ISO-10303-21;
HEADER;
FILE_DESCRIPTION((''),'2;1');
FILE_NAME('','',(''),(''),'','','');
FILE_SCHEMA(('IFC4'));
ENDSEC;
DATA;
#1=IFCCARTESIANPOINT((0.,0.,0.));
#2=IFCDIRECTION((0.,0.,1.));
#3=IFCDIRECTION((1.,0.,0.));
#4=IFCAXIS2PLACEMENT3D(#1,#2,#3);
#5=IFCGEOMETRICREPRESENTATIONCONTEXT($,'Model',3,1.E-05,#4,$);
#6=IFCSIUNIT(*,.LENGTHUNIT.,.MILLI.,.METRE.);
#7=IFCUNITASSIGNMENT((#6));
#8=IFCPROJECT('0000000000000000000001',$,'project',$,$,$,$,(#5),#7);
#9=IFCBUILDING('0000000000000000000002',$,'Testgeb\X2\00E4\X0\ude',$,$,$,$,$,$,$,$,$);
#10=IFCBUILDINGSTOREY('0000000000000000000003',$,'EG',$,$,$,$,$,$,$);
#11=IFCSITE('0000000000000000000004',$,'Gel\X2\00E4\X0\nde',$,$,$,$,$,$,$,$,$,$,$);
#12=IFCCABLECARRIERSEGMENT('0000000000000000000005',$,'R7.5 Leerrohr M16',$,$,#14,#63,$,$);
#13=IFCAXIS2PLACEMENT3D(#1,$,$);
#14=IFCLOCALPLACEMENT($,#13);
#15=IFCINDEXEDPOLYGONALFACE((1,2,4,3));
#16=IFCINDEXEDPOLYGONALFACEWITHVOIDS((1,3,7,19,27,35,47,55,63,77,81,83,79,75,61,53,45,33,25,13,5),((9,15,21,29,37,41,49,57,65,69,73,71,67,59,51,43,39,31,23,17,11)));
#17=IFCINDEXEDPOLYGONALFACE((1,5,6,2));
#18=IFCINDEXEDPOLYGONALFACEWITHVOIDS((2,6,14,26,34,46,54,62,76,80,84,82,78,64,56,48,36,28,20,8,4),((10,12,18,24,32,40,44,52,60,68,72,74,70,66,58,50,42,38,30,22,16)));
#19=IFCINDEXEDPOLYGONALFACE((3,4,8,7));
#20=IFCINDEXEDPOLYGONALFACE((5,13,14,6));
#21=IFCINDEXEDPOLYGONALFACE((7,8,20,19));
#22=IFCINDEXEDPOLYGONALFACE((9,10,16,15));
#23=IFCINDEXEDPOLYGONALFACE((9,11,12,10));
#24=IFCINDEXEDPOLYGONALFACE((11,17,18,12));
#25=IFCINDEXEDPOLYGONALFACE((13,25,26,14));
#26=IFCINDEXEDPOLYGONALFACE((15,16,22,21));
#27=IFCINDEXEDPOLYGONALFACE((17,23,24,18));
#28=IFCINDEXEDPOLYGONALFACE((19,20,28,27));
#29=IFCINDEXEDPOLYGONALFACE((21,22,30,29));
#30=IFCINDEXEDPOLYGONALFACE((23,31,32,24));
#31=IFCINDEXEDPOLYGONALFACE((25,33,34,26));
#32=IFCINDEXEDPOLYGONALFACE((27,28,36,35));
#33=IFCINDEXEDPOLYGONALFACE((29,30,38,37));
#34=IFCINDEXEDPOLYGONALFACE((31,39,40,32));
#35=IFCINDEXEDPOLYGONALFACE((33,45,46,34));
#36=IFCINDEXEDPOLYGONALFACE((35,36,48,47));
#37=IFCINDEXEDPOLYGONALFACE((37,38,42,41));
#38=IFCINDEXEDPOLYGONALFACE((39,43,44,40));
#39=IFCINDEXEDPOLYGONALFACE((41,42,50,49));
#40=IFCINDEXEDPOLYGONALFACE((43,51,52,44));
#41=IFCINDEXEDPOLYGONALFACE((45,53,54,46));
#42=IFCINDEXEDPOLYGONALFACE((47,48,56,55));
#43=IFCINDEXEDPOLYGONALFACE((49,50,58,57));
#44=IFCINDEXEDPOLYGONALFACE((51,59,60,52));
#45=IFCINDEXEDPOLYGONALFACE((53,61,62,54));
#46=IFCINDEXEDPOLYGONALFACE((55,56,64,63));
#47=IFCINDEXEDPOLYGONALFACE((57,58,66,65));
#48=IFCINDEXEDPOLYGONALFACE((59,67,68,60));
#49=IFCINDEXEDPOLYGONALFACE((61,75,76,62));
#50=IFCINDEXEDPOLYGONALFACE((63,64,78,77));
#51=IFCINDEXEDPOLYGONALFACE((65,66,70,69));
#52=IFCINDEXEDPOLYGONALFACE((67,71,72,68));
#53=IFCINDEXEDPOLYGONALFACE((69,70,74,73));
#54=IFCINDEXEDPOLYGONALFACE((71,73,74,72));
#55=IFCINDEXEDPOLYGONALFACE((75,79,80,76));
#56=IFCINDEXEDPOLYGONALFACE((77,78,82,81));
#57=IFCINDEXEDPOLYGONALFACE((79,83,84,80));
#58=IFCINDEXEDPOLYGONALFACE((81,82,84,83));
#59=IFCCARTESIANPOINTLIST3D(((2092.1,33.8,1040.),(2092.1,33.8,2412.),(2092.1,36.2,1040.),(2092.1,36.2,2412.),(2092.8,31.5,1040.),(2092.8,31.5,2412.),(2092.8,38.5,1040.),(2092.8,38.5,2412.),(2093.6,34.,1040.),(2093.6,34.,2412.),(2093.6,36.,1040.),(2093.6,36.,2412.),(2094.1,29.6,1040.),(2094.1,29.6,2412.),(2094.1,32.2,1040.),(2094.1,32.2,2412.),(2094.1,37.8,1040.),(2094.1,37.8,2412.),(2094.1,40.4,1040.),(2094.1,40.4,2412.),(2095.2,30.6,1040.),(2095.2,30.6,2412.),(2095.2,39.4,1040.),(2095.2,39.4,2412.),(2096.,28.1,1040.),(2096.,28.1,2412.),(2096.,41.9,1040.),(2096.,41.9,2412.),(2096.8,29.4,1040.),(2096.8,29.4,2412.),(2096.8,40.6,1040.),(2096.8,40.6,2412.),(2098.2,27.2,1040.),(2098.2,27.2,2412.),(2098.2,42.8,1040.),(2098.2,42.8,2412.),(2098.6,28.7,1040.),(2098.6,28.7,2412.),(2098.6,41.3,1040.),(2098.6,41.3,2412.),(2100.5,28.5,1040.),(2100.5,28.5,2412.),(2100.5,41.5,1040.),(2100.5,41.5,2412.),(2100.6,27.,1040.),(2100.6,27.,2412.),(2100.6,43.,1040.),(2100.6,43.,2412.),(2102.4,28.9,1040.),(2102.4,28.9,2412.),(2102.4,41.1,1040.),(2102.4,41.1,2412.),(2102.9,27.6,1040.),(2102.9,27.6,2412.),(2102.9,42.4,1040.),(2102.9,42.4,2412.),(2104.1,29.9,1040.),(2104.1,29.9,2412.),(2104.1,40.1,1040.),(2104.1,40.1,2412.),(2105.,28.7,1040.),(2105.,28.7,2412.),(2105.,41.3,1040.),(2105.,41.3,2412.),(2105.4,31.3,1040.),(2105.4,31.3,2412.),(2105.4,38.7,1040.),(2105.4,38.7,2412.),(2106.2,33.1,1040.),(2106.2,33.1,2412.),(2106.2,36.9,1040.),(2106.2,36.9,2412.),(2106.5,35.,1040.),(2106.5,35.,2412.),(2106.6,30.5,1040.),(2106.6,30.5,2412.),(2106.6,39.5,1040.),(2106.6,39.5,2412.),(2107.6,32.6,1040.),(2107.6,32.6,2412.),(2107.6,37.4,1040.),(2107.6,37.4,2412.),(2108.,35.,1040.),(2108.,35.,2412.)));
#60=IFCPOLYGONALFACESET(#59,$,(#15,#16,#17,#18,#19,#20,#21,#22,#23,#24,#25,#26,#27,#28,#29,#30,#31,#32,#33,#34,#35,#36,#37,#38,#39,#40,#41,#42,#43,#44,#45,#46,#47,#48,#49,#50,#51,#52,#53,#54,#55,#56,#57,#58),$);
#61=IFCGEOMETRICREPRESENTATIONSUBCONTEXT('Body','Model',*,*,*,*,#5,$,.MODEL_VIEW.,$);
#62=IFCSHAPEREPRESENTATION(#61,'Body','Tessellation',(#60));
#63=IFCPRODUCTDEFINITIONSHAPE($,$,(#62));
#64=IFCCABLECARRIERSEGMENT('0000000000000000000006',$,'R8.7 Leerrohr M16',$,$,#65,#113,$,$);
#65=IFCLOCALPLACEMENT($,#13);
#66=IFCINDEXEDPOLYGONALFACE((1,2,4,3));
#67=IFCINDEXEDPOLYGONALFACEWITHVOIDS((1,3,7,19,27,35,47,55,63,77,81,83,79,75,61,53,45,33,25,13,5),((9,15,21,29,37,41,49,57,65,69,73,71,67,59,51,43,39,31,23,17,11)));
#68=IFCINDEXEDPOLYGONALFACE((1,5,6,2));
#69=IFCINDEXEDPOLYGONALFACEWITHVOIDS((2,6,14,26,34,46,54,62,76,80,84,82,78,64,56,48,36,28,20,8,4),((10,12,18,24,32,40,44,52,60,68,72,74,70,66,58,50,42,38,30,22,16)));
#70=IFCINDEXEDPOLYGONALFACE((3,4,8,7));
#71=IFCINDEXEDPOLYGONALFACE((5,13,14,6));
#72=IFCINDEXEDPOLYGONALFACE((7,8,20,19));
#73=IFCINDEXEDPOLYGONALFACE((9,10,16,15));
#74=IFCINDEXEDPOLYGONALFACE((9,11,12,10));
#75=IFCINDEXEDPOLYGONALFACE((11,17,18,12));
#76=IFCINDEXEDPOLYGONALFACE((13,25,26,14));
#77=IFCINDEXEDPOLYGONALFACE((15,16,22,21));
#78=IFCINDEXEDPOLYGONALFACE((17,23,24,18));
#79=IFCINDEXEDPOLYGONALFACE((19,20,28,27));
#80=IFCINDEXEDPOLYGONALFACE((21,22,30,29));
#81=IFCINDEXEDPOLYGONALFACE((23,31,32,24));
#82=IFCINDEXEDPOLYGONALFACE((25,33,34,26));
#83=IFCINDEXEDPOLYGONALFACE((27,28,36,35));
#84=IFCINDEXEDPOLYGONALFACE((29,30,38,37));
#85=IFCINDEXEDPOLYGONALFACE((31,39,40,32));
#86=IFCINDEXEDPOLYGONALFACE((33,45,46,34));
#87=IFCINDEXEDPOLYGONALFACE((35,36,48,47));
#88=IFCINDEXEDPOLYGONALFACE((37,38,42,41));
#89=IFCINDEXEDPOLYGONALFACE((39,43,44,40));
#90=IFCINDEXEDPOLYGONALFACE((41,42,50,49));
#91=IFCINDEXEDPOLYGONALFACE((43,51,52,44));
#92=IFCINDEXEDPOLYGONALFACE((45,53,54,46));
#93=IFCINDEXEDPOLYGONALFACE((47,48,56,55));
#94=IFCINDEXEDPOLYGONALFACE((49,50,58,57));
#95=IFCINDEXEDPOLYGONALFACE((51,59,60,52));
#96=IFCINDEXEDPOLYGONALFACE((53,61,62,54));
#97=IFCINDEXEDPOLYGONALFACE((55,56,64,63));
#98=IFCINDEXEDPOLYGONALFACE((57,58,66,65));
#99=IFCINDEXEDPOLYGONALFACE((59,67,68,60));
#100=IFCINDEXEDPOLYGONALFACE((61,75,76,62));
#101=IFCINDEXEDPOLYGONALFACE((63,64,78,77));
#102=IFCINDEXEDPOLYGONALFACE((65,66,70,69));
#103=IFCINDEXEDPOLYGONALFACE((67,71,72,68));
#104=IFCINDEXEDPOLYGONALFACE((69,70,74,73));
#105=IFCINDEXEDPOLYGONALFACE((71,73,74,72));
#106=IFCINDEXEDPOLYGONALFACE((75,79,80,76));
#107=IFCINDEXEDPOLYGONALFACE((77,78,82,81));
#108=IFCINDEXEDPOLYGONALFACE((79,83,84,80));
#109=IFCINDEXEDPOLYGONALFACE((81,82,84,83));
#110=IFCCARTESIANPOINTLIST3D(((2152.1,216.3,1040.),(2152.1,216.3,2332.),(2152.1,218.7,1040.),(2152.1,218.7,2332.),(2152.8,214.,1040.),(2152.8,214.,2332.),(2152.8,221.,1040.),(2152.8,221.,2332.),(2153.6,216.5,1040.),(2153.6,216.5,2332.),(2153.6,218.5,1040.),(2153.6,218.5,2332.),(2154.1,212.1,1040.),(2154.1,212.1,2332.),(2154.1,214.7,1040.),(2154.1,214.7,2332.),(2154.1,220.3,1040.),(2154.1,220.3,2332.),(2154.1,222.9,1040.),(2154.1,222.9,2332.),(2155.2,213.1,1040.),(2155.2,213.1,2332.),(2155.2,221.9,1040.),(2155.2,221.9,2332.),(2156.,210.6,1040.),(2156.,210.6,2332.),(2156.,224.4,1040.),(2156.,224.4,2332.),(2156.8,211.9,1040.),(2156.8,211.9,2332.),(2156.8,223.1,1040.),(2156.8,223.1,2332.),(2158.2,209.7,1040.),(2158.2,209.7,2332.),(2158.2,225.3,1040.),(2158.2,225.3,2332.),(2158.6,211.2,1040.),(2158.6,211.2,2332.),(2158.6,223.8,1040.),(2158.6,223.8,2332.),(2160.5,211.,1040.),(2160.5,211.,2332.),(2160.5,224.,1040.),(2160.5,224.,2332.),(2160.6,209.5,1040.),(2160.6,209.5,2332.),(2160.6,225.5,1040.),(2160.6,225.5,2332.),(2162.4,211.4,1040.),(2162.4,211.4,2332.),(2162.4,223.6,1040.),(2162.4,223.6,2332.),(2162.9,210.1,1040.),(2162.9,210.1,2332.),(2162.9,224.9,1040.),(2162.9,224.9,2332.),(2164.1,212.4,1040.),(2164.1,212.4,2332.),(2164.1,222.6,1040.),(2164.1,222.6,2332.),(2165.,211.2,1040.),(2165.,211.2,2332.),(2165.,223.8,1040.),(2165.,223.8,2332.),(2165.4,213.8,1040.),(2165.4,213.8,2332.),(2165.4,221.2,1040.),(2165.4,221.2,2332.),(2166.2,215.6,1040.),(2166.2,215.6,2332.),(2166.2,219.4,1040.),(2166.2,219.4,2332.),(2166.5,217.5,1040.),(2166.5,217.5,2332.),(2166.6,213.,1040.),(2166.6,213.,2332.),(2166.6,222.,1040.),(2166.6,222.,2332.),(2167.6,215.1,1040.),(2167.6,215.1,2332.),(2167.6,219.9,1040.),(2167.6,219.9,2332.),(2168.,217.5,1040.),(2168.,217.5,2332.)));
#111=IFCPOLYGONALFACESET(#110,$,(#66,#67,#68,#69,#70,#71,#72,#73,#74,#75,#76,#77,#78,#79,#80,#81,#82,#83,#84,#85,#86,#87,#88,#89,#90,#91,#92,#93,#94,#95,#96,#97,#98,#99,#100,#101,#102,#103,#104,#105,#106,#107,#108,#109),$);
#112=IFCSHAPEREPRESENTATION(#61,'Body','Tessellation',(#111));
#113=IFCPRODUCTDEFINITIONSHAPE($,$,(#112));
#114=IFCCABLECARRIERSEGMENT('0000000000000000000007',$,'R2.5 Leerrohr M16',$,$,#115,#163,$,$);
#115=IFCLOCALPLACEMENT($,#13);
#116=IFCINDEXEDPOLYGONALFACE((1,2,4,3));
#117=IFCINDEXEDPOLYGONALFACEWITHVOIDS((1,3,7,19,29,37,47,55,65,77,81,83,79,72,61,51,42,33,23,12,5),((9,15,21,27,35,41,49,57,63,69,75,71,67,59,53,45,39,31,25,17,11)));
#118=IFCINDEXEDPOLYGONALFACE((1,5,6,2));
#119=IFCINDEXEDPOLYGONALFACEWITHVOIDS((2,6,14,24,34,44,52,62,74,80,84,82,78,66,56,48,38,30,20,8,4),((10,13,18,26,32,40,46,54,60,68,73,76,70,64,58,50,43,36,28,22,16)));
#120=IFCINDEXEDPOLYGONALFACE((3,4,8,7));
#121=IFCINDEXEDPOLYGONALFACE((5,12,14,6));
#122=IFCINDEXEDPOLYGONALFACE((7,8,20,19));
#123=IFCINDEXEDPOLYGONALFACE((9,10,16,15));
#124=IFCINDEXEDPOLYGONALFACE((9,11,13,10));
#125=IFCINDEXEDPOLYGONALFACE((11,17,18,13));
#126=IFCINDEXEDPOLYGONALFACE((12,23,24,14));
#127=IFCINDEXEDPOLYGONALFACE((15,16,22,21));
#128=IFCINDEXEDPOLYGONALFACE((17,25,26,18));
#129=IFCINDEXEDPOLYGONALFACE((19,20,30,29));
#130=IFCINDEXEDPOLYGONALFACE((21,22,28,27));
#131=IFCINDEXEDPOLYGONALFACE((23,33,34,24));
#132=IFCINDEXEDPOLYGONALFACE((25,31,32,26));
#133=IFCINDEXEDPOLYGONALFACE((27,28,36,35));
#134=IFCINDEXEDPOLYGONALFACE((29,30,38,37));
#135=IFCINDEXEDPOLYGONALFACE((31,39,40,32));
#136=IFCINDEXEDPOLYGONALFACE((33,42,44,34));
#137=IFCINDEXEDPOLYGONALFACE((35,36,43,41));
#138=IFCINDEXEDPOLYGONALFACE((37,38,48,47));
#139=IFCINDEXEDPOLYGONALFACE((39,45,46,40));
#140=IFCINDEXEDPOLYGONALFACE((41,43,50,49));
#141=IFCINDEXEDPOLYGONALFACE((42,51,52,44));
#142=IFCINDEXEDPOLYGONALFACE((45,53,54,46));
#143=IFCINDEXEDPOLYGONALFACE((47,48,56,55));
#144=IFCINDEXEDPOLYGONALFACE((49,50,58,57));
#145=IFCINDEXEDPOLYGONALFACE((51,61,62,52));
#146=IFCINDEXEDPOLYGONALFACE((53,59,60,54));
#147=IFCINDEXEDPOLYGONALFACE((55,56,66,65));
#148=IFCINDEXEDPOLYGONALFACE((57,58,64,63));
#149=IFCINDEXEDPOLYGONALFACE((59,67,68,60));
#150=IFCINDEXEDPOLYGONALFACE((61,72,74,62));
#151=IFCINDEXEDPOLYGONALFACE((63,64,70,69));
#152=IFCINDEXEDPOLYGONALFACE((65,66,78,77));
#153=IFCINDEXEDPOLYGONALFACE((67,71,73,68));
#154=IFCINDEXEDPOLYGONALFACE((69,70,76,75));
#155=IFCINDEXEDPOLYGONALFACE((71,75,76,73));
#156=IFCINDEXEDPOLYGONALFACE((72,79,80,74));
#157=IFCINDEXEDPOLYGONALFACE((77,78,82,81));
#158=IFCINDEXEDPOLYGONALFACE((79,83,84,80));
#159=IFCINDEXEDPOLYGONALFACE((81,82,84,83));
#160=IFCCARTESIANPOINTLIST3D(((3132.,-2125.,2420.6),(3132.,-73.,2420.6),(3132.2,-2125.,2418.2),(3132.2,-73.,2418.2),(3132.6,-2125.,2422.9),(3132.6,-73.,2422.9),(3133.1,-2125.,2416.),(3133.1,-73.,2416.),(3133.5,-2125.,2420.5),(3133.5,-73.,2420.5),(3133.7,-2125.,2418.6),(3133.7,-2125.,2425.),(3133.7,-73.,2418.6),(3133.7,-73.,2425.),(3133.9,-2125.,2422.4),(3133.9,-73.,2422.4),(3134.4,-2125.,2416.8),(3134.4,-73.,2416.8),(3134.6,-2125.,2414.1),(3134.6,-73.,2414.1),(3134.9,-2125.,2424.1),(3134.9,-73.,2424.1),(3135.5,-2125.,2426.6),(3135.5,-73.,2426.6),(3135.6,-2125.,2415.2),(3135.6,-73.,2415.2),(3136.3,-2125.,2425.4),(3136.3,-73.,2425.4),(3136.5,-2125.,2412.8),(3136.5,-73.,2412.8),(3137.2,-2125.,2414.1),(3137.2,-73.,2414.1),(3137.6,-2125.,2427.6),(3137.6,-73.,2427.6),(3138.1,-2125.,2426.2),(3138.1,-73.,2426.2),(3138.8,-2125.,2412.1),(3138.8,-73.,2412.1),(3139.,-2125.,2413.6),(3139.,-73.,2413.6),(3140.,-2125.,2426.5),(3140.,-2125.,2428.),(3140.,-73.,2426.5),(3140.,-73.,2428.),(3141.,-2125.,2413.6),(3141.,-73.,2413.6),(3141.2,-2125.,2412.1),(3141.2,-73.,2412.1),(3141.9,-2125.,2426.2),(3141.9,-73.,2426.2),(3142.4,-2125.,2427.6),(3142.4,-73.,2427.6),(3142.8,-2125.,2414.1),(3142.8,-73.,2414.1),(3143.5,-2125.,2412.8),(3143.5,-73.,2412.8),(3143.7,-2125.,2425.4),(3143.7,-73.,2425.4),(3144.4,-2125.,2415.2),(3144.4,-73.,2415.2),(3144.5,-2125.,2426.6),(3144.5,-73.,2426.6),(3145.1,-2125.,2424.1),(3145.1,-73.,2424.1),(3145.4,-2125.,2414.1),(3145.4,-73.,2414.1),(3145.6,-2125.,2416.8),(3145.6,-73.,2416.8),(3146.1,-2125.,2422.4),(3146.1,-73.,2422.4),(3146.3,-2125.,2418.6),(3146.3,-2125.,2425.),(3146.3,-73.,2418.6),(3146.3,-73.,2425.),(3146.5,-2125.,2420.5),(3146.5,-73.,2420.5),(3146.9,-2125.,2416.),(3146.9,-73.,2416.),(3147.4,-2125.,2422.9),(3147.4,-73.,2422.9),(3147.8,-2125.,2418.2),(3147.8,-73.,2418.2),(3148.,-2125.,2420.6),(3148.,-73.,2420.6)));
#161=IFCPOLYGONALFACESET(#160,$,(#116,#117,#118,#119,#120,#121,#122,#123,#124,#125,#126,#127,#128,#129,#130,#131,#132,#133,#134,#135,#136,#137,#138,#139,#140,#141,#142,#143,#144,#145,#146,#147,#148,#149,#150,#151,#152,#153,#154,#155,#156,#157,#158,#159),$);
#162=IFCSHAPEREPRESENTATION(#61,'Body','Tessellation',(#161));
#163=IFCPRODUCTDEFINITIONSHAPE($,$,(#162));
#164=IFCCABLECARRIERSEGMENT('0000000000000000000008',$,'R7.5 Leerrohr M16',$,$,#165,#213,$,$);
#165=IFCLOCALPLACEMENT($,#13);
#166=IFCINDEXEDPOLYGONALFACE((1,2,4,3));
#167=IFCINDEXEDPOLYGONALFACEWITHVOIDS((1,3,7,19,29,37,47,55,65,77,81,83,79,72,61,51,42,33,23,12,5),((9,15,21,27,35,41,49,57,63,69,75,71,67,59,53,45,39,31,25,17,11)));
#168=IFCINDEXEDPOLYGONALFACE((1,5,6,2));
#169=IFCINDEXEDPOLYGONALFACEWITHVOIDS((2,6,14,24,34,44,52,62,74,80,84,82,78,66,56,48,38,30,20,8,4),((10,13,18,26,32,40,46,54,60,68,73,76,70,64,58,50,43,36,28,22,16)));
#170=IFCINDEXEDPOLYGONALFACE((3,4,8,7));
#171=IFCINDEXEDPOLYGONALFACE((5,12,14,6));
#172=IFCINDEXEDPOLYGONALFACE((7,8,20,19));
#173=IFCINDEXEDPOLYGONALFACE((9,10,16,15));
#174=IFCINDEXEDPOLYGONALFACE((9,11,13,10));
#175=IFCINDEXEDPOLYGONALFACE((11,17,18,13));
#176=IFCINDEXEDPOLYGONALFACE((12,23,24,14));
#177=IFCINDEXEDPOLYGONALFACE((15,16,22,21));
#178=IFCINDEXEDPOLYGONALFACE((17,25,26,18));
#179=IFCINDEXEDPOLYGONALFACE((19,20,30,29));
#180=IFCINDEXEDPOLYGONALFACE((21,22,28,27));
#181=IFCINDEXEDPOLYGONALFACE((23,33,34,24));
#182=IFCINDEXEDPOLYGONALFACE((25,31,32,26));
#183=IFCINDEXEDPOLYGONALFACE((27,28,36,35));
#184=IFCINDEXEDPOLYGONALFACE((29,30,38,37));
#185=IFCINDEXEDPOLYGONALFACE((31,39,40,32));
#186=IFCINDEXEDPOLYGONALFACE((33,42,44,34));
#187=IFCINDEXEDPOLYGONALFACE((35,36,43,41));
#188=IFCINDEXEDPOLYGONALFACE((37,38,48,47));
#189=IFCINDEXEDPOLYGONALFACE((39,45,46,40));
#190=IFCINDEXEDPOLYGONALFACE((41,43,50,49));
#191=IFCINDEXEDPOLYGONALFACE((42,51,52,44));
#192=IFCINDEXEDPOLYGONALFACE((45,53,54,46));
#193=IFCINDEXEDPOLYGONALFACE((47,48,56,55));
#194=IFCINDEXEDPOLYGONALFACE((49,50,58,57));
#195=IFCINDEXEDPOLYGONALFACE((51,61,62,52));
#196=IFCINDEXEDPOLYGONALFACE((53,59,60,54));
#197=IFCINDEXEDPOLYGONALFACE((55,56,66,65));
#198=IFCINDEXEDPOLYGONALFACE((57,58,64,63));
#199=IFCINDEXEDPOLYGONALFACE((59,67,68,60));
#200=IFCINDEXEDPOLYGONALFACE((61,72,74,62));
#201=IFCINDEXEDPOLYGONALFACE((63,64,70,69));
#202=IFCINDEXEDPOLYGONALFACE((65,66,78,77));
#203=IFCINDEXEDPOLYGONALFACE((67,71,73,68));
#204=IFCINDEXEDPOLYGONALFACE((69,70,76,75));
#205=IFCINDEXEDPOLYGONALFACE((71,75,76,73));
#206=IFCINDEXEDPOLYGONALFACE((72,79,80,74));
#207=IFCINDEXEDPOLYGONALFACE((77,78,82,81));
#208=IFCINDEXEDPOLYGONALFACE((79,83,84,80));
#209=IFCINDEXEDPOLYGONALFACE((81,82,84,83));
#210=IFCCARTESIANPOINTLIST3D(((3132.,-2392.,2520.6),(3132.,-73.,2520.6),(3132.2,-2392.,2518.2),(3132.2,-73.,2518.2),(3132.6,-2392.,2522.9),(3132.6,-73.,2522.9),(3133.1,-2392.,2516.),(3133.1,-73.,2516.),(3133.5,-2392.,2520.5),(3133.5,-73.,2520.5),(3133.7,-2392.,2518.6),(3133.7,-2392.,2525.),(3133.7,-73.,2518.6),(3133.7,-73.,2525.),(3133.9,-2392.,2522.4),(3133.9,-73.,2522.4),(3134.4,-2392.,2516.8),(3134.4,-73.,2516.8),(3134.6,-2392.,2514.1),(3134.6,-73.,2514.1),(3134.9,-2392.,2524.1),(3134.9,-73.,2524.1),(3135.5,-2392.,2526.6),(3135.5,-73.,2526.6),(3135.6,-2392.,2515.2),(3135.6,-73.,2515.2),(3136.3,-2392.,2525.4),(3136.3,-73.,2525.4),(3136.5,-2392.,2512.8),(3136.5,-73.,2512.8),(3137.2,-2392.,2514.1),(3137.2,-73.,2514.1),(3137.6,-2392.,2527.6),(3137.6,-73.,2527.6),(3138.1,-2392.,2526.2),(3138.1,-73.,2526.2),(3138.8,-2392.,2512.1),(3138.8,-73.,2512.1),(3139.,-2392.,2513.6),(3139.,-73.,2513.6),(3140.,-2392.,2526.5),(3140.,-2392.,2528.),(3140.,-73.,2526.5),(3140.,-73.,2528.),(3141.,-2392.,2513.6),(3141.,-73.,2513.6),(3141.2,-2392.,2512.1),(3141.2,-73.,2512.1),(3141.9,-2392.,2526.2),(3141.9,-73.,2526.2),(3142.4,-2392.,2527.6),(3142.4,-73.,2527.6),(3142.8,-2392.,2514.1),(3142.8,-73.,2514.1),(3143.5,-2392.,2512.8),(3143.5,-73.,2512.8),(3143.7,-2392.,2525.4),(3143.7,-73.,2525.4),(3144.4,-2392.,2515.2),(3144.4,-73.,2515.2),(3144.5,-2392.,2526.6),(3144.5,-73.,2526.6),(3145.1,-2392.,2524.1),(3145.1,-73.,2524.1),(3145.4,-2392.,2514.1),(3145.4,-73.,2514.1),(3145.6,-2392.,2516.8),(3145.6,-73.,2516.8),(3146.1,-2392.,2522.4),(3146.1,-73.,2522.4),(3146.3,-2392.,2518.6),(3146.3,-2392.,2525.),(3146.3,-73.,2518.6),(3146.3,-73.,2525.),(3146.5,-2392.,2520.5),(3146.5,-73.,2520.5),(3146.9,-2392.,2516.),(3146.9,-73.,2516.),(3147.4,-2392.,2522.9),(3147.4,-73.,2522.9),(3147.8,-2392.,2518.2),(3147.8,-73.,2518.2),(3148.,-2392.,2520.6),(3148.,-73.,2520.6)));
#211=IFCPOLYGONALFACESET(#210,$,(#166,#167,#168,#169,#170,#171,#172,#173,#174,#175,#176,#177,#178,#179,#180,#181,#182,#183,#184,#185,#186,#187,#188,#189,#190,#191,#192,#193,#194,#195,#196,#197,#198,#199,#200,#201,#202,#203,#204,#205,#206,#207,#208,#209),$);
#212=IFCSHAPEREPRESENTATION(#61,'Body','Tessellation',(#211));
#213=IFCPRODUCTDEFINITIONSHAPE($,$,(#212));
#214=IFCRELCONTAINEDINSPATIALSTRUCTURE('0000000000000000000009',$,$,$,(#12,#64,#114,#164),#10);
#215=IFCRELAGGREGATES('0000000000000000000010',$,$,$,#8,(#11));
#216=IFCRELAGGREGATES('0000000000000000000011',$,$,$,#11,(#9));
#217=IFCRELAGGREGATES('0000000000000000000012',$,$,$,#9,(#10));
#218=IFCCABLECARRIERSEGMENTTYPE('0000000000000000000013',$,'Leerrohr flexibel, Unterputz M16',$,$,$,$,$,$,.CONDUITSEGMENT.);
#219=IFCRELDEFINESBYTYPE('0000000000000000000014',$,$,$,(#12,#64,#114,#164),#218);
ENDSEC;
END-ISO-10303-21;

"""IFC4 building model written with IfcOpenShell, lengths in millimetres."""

from ifc_helpers import new_model, si_unit, frame, origin_with_axes, place, context, subcontext, project, spatial, hollow_circle, extrude, type_object, element, save


model = new_model("IFC4")

# Units and contexts
model_context = context("Model", 3, precision=1e-05, world=origin_with_axes())
body_context = subcontext(model_context, "Body", "Model", "MODEL_VIEW")
ifc_project = project(units=[si_unit("LENGTHUNIT", "METRE", prefix="MILLI")], contexts=[model_context])

# Site, building, storey
site = spatial("IfcSite", under=ifc_project, Name="Gelände")
building = spatial("IfcBuilding", under=site, Name="Testgebäude")
storey = spatial("IfcBuildingStorey", under=building, Name="EG")

# Cable carrier segments
cable_carrier_segment_type_1 = type_object("IfcCableCarrierSegmentType", Name="Leerrohr flexibel, Unterputz M16", PredefinedType="CONDUITSEGMENT")
cable_carrier_segment_1_placement = place(None, frame((2100.0, 35.0, 2412.0), z_axis=(0.0, 0.0, -1.0), x_axis=(1.0, 0.0, 0.0)))
element("IfcCableCarrierSegment", 1, at=cable_carrier_segment_1_placement, inside=storey, type_object=cable_carrier_segment_type_1, Name="R7.5 Leerrohr M16", context=body_context, shape_type="SweptSolid", body=[
    extrude(hollow_circle(Radius=8.0, WallThickness=1.5), None, (0.0, 0.0, 1.0), 1372.0),
])
cable_carrier_segment_2_placement = place(None, frame((2160.0, 217.5, 2332.0), z_axis=(0.0, 0.0, -1.0), x_axis=(1.0, 0.0, 0.0)))
element("IfcCableCarrierSegment", 2, at=cable_carrier_segment_2_placement, inside=storey, type_object=cable_carrier_segment_type_1, Name="R8.7 Leerrohr M16", context=body_context, shape_type="SweptSolid", body=[
    extrude(hollow_circle(Radius=8.0, WallThickness=1.5), None, (0.0, 0.0, 1.0), 1292.0),
])
cable_carrier_segment_3_placement = place(None, frame((3140.0, -73.0, 2420.0), z_axis=(0.0, -1.0, 0.0), x_axis=(0.0, 0.0, 1.0)))
element("IfcCableCarrierSegment", 3, at=cable_carrier_segment_3_placement, inside=storey, type_object=cable_carrier_segment_type_1, Name="R2.5 Leerrohr M16", context=body_context, shape_type="SweptSolid", body=[
    extrude(hollow_circle(Radius=8.0, WallThickness=1.5), None, (0.0, 0.0, 1.0), 2052.0),
])
cable_carrier_segment_4_placement = place(None, frame((3140.0, -73.0, 2520.0), z_axis=(0.0, -1.0, 0.0), x_axis=(0.0, 0.0, 1.0)))
element("IfcCableCarrierSegment", 4, at=cable_carrier_segment_4_placement, inside=storey, type_object=cable_carrier_segment_type_1, Name="R7.5 Leerrohr M16", context=body_context, shape_type="SweptSolid", body=[
    extrude(hollow_circle(Radius=8.0, WallThickness=1.5), None, (0.0, 0.0, 1.0), 2319.0),
])

save(model, "model.ifc")
